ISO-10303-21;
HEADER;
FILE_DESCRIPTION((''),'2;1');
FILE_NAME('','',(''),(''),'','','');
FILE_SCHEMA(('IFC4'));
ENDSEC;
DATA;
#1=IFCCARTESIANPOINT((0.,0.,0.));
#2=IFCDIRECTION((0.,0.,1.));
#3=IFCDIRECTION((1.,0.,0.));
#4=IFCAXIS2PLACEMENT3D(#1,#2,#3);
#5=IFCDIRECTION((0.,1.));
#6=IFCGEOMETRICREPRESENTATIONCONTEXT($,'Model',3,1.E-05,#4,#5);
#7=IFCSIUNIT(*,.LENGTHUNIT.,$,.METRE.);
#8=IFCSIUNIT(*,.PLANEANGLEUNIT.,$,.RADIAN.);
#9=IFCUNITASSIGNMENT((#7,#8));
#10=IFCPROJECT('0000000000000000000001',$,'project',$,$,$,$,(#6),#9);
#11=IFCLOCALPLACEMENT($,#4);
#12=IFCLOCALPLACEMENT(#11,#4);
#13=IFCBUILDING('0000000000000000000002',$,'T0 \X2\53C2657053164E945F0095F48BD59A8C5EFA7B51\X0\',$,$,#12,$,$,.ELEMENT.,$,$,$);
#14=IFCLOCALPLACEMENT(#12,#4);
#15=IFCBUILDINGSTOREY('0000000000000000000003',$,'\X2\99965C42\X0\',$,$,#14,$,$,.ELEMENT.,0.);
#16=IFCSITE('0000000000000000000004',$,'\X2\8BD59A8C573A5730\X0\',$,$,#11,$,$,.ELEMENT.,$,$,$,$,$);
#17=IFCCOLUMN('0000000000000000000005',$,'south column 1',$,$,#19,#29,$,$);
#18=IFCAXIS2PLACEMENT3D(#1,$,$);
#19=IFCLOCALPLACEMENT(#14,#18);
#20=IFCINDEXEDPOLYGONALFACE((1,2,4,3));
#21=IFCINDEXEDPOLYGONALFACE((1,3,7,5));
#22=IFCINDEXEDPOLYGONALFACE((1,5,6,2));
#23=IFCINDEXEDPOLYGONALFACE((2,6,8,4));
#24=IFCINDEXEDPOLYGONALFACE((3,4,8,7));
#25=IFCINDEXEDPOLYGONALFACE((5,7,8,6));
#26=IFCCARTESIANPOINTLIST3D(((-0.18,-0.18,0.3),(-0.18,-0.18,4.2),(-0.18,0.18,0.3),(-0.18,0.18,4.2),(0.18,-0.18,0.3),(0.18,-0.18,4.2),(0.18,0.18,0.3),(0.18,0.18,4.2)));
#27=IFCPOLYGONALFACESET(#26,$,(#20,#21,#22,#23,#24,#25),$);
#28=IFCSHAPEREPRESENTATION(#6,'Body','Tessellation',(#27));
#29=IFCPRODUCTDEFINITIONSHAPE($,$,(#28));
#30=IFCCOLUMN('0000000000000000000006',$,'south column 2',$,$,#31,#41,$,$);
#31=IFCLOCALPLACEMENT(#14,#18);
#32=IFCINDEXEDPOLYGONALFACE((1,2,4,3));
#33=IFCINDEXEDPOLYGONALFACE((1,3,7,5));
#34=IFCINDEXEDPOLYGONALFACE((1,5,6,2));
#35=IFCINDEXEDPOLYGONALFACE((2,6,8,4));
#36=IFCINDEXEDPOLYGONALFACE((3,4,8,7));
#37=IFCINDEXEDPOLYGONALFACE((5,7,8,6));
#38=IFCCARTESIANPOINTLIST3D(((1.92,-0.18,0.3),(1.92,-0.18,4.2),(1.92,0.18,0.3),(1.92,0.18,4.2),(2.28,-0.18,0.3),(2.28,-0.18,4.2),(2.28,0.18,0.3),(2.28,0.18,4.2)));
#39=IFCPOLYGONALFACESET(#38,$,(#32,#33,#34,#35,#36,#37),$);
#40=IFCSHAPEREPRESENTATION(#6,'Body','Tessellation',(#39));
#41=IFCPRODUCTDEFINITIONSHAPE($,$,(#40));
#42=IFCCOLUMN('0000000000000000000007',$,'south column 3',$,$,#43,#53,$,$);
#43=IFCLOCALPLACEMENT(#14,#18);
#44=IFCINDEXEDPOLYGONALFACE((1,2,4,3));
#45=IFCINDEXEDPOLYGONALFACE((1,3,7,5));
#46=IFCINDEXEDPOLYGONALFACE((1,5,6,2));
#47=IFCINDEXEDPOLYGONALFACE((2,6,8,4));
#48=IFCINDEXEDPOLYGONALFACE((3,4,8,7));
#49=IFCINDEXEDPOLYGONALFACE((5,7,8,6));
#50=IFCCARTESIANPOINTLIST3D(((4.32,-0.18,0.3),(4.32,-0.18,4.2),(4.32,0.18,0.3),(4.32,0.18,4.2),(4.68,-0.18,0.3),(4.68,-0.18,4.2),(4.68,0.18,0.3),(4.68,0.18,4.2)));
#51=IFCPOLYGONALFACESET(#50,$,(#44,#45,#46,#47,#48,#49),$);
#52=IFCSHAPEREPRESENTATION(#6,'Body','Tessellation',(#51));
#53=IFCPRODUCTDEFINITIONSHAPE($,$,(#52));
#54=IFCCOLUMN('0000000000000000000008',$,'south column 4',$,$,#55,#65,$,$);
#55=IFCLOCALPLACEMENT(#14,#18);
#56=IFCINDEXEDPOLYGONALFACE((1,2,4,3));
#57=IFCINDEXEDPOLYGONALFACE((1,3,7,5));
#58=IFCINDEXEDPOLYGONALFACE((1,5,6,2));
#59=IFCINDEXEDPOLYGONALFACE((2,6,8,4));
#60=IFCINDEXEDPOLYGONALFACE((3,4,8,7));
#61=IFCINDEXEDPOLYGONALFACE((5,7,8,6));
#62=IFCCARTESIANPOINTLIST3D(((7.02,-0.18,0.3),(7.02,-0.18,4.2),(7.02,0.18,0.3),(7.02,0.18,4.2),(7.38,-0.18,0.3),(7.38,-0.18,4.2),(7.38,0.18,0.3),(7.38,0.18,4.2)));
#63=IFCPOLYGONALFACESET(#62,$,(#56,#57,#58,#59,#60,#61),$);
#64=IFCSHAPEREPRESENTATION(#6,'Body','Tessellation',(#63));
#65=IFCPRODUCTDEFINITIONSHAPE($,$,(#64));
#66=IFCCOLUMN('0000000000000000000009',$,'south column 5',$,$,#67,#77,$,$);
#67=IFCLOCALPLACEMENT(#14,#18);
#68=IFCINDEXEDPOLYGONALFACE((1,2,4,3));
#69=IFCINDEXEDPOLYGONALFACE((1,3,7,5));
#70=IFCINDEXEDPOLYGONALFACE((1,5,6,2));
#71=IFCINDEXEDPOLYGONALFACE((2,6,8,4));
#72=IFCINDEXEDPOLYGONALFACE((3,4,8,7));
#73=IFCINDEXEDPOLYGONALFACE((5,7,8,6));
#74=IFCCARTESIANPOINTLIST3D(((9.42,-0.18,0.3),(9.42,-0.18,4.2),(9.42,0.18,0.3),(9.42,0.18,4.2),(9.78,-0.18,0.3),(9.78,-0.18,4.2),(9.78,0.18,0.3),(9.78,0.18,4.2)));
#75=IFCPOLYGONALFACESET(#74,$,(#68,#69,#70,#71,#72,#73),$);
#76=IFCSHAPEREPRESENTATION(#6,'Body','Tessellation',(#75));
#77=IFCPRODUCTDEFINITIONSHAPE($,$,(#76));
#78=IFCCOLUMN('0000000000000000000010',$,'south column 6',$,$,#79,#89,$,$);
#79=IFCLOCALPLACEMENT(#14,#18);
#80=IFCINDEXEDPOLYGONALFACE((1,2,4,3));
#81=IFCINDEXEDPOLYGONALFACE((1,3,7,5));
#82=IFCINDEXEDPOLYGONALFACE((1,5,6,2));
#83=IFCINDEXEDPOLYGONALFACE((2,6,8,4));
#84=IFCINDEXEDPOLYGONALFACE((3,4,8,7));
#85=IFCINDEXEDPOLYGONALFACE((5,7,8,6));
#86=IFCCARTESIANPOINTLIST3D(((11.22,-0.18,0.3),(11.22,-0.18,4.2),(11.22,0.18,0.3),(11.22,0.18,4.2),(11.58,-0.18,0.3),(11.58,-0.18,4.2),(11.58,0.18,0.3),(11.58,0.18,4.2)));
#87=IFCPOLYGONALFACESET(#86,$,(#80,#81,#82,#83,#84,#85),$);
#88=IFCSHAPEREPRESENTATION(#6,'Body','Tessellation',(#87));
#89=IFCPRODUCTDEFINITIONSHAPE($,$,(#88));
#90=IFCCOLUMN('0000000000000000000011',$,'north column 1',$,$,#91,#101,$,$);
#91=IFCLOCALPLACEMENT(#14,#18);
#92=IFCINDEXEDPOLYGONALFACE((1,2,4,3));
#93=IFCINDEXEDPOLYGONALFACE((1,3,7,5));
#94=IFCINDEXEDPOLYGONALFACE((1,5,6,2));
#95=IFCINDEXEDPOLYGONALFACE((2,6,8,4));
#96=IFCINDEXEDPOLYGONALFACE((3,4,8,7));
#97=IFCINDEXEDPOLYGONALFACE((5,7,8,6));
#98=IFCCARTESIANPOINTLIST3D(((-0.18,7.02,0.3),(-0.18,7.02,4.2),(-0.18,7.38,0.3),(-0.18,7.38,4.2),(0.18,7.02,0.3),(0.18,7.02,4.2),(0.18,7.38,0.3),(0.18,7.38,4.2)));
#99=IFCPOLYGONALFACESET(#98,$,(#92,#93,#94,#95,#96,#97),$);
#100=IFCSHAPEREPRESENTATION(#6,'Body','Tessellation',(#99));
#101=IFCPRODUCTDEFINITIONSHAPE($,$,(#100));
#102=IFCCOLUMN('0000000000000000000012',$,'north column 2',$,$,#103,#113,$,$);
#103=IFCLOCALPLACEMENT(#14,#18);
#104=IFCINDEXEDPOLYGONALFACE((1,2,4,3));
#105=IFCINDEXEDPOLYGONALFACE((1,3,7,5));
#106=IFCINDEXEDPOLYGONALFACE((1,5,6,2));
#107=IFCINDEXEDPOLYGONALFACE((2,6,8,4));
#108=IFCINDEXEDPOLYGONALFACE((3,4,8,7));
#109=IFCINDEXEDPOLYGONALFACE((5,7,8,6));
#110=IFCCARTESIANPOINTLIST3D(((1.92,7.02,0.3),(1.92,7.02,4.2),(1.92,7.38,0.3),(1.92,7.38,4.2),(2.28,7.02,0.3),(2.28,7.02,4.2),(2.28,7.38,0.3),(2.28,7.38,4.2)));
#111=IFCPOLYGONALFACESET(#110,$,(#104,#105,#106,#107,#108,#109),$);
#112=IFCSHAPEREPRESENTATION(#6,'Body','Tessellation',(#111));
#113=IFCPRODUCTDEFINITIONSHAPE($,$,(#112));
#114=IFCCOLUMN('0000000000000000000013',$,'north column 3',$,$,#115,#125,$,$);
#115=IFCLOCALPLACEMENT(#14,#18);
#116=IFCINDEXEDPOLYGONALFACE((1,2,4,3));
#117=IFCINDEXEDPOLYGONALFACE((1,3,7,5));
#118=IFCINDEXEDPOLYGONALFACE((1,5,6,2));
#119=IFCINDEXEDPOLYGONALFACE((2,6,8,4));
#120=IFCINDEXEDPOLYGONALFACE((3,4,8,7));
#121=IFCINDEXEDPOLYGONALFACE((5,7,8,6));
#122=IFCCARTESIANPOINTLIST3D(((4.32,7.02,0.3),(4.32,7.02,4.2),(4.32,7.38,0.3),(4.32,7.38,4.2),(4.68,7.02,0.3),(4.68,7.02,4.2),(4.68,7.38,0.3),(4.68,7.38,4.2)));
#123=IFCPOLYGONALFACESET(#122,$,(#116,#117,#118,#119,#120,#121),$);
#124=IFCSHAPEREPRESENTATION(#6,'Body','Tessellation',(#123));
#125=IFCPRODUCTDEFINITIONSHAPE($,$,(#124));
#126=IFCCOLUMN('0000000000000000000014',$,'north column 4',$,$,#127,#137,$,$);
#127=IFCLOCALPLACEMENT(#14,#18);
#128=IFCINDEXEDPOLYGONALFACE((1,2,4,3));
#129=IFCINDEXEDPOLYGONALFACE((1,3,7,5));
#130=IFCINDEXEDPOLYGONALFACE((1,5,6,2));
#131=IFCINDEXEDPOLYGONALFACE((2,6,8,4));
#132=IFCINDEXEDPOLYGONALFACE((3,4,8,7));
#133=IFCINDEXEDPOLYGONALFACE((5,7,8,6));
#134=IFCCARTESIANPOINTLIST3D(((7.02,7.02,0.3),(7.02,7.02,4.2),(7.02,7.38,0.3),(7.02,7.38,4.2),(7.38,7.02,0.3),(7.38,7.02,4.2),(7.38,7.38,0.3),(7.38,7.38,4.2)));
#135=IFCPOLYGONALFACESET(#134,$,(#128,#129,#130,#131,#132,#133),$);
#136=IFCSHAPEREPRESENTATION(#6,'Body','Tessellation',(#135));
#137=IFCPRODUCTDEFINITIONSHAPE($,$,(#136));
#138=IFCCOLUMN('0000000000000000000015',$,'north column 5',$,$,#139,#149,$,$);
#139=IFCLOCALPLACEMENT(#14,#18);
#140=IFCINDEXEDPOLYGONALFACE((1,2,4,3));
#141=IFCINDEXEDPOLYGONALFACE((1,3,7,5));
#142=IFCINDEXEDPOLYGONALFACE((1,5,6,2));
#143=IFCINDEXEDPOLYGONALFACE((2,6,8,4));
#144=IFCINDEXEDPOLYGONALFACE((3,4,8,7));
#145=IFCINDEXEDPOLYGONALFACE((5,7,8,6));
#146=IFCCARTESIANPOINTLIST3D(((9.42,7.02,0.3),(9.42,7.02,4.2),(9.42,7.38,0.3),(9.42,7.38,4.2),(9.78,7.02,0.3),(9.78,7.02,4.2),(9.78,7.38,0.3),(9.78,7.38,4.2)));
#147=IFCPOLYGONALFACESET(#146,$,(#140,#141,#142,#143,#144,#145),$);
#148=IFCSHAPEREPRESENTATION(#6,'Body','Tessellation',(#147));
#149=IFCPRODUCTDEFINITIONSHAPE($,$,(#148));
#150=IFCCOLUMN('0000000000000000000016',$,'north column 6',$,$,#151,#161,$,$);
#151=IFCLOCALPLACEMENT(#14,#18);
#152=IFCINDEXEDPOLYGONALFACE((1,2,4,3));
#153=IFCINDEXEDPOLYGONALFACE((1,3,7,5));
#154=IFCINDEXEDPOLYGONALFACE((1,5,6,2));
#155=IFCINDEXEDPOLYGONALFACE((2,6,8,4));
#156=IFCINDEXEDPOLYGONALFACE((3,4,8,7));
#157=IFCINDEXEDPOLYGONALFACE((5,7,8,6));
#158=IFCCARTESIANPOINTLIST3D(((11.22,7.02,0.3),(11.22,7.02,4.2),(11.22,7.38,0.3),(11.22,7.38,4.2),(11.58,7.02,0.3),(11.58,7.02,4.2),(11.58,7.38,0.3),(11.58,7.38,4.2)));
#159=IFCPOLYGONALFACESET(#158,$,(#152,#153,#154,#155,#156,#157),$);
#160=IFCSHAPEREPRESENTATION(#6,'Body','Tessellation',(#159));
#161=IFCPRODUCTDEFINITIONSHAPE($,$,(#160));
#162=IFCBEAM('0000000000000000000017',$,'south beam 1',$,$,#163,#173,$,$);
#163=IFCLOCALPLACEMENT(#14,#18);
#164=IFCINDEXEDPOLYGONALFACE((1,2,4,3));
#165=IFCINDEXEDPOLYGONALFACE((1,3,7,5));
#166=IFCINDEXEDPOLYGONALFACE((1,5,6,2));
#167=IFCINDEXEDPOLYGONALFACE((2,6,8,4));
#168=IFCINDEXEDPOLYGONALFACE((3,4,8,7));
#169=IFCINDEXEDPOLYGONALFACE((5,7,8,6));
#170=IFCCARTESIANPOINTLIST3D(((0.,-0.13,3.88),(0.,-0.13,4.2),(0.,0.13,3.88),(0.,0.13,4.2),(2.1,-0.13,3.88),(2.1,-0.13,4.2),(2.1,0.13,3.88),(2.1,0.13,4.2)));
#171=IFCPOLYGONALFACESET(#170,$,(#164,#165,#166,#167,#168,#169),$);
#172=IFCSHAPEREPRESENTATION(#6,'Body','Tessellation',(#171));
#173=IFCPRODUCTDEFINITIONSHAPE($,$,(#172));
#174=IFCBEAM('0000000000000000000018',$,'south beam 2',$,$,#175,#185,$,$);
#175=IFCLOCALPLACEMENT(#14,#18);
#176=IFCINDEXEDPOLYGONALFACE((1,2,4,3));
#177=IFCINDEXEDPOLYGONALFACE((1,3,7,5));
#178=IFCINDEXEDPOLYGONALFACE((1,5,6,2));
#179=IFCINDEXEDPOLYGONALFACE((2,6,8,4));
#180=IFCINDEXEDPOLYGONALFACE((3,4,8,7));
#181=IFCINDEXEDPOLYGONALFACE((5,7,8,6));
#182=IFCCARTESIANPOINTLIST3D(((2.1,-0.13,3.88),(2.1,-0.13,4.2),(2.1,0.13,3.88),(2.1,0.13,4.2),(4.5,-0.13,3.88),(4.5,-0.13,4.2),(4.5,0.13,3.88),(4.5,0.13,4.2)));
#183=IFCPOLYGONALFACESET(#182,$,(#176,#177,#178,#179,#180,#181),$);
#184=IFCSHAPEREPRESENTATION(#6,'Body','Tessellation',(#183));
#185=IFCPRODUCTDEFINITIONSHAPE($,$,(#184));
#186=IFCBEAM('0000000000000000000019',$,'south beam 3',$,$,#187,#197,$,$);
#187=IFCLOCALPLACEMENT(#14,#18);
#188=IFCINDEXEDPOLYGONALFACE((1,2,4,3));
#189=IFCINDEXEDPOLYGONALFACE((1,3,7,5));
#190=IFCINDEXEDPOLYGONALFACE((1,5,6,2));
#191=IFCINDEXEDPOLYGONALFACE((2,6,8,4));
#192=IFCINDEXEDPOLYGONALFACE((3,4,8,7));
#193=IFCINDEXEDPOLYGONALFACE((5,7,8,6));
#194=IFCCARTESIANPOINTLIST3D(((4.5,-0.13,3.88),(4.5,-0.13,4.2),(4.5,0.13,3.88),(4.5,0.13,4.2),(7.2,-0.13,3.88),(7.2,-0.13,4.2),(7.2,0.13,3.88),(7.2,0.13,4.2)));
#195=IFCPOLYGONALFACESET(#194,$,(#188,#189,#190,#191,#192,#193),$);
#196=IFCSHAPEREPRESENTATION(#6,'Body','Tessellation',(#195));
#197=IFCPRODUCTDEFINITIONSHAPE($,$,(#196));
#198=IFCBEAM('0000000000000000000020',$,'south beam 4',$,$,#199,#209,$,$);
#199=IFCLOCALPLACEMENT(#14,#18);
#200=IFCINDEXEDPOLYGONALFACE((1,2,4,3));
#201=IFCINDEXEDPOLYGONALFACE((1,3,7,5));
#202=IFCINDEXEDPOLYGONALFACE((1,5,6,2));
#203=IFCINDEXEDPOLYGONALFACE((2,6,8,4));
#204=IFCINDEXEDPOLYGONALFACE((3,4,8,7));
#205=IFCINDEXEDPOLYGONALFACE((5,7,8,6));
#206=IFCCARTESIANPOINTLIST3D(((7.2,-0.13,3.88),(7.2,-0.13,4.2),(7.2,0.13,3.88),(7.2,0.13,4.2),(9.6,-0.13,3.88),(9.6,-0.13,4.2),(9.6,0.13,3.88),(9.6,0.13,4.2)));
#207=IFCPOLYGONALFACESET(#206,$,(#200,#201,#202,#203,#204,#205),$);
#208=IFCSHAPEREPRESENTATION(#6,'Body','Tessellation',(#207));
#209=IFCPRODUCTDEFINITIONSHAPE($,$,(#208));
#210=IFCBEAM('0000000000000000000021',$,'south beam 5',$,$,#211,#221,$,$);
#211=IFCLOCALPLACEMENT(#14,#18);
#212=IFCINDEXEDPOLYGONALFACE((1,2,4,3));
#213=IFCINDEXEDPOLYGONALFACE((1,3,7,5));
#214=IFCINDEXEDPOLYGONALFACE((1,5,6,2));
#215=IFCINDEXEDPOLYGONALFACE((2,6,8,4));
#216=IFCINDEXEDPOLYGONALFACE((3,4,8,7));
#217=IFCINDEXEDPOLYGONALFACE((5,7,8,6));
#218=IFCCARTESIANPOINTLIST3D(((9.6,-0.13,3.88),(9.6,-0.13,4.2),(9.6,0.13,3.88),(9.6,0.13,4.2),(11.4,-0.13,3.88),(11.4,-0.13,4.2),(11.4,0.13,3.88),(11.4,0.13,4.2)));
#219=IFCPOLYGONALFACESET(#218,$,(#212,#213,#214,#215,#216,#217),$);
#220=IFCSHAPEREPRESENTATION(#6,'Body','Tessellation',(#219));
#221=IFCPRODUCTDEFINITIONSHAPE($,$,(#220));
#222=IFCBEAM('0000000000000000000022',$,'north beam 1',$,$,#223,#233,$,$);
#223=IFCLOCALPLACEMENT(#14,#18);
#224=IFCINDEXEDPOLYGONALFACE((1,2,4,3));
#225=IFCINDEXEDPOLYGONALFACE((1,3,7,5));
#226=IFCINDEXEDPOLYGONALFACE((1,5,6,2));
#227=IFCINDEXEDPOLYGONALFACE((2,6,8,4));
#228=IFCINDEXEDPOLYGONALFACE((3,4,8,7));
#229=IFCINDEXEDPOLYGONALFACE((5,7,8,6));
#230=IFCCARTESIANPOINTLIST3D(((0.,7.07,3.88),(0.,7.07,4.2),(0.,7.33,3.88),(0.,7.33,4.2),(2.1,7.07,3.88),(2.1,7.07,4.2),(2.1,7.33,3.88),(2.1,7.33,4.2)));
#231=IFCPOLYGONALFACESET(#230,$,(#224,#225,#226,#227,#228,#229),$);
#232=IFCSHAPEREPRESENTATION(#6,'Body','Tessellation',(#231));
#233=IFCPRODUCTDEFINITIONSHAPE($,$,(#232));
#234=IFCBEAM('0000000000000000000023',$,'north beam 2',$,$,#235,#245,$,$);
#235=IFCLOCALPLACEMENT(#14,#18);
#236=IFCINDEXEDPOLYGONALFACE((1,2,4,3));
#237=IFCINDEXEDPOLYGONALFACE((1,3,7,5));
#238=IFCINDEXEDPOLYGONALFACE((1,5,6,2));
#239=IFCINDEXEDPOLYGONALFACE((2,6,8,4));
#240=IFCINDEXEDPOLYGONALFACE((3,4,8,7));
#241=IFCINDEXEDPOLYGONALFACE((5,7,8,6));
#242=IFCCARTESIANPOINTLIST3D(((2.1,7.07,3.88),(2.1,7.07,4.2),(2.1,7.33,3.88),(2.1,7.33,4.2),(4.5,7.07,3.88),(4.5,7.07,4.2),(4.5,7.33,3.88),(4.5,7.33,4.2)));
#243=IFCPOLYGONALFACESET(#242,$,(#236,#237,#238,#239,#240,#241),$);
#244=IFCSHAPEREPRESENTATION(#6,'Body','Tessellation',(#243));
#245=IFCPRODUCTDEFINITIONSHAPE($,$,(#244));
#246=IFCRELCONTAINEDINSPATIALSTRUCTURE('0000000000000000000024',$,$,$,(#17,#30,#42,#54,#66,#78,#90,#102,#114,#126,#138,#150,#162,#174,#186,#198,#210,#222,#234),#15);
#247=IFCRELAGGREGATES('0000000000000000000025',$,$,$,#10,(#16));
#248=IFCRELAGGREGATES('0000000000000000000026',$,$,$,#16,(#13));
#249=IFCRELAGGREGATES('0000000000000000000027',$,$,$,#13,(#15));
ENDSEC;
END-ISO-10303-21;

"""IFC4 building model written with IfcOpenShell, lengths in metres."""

from ifc_helpers import new_model, si_unit, direction, frame, origin_with_axes, origin_2d_with_axis, place, context, project, spatial, rectangle, extrude, element, save


model = new_model("IFC4")

# Units and contexts
model_context = context("Model", 3, precision=1e-05, world=origin_with_axes(), true_north=direction((0.0, 1.0)))
ifc_project = project(units=[si_unit("LENGTHUNIT", "METRE"), si_unit("PLANEANGLEUNIT", "RADIAN")], contexts=[model_context])

# Site, building, storey
site_placement = place(None, origin_with_axes())
site = spatial("IfcSite", under=ifc_project, at=site_placement, Name="试验场地", CompositionType="ELEMENT")
building_placement = place(site_placement, origin_with_axes())
building = spatial("IfcBuilding", under=site, at=building_placement, Name="T0 参数化五开间试验建筑", CompositionType="ELEMENT")
storey_placement = place(building_placement, origin_with_axes())
storey = spatial("IfcBuildingStorey", under=building, at=storey_placement, Name="首层", CompositionType="ELEMENT", Elevation=0.0)

# Columns
for number, where, z_axis, x_axis, name in (
    (1, (0.0, 0.0, 0.3), (0.0, 0.0, 1.0), (1.0, 0.0, 0.0), "south column 1"),
    (2, (2.1, 0.0, 0.3), (0.0, 0.0, 1.0), (1.0, 0.0, 0.0), "south column 2"),
    (3, (4.5, 0.0, 0.3), (0.0, 0.0, 1.0), (1.0, 0.0, 0.0), "south column 3"),
    (4, (7.2, 0.0, 0.3), (0.0, 0.0, 1.0), (1.0, 0.0, 0.0), "south column 4"),
    (5, (9.6, 0.0, 0.3), (0.0, 0.0, 1.0), (1.0, 0.0, 0.0), "south column 5"),
    (6, (11.4, 0.0, 0.3), (0.0, 0.0, 1.0), (1.0, 0.0, 0.0), "south column 6"),
    (7, (0.0, 7.2, 0.3), (0.0, 0.0, 1.0), (1.0, 0.0, 0.0), "north column 1"),
    (8, (2.1, 7.2, 0.3), (0.0, 0.0, 1.0), (1.0, 0.0, 0.0), "north column 2"),
    (9, (4.5, 7.2, 0.3), (0.0, 0.0, 1.0), (1.0, 0.0, 0.0), "north column 3"),
    (10, (7.2, 7.2, 0.3), (0.0, 0.0, 1.0), (1.0, 0.0, 0.0), "north column 4"),
    (11, (9.6, 7.2, 0.3), (0.0, 0.0, 1.0), (1.0, 0.0, 0.0), "north column 5"),
    (12, (11.4, 7.2, 0.3), (0.0, 0.0, 1.0), (1.0, 0.0, 0.0), "north column 6"),
):
    element("IfcColumn", number, at=place(storey_placement, frame(where, z_axis=z_axis, x_axis=x_axis)), inside=storey, Name=name, context=model_context, shape_type="SweptSolid", body=[
        extrude(rectangle(XDim=0.36, YDim=0.36, at=origin_2d_with_axis()), origin_with_axes(), (0.0, 0.0, 1.0), 3.9),
    ])

# Beams
beam_1_placement = place(storey_placement, frame((1.05, 0.0, 3.88), z_axis=(0.0, 0.0, 1.0), x_axis=(1.0, 0.0, 0.0)))
element("IfcBeam", 13, at=beam_1_placement, inside=storey, Name="south beam 1", context=model_context, shape_type="SweptSolid", body=[
    extrude(rectangle(XDim=2.1, YDim=0.26, at=origin_2d_with_axis()), origin_with_axes(), (0.0, 0.0, 1.0), 0.32),
])
beam_2_placement = place(storey_placement, frame((3.3, 0.0, 3.88), z_axis=(0.0, 0.0, 1.0), x_axis=(1.0, 0.0, 0.0)))
element("IfcBeam", 14, at=beam_2_placement, inside=storey, Name="south beam 2", context=model_context, shape_type="SweptSolid", body=[
    extrude(rectangle(XDim=2.4, YDim=0.26, at=origin_2d_with_axis()), origin_with_axes(), (0.0, 0.0, 1.0), 0.32),
])
beam_3_placement = place(storey_placement, frame((5.85, 0.0, 3.88), z_axis=(0.0, 0.0, 1.0), x_axis=(1.0, 0.0, 0.0)))
element("IfcBeam", 15, at=beam_3_placement, inside=storey, Name="south beam 3", context=model_context, shape_type="SweptSolid", body=[
    extrude(rectangle(XDim=2.7, YDim=0.26, at=origin_2d_with_axis()), origin_with_axes(), (0.0, 0.0, 1.0), 0.32),
])
beam_4_placement = place(storey_placement, frame((8.4, 0.0, 3.88), z_axis=(0.0, 0.0, 1.0), x_axis=(1.0, 0.0, 0.0)))
element("IfcBeam", 16, at=beam_4_placement, inside=storey, Name="south beam 4", context=model_context, shape_type="SweptSolid", body=[
    extrude(rectangle(XDim=2.4, YDim=0.26, at=origin_2d_with_axis()), origin_with_axes(), (0.0, 0.0, 1.0), 0.32),
])
beam_5_placement = place(storey_placement, frame((10.5, 0.0, 3.88), z_axis=(0.0, 0.0, 1.0), x_axis=(1.0, 0.0, 0.0)))
element("IfcBeam", 17, at=beam_5_placement, inside=storey, Name="south beam 5", context=model_context, shape_type="SweptSolid", body=[
    extrude(rectangle(XDim=1.8, YDim=0.26, at=origin_2d_with_axis()), origin_with_axes(), (0.0, 0.0, 1.0), 0.32),
])
beam_6_placement = place(storey_placement, frame((1.05, 7.2, 3.88), z_axis=(0.0, 0.0, 1.0), x_axis=(1.0, 0.0, 0.0)))
element("IfcBeam", 18, at=beam_6_placement, inside=storey, Name="north beam 1", context=model_context, shape_type="SweptSolid", body=[
    extrude(rectangle(XDim=2.1, YDim=0.26, at=origin_2d_with_axis()), origin_with_axes(), (0.0, 0.0, 1.0), 0.32),
])
beam_7_placement = place(storey_placement, frame((3.3, 7.2, 3.88), z_axis=(0.0, 0.0, 1.0), x_axis=(1.0, 0.0, 0.0)))
element("IfcBeam", 19, at=beam_7_placement, inside=storey, Name="north beam 2", context=model_context, shape_type="SweptSolid", body=[
    extrude(rectangle(XDim=2.4, YDim=0.26, at=origin_2d_with_axis()), origin_with_axes(), (0.0, 0.0, 1.0), 0.32),
])

save(model, "model.ifc")
